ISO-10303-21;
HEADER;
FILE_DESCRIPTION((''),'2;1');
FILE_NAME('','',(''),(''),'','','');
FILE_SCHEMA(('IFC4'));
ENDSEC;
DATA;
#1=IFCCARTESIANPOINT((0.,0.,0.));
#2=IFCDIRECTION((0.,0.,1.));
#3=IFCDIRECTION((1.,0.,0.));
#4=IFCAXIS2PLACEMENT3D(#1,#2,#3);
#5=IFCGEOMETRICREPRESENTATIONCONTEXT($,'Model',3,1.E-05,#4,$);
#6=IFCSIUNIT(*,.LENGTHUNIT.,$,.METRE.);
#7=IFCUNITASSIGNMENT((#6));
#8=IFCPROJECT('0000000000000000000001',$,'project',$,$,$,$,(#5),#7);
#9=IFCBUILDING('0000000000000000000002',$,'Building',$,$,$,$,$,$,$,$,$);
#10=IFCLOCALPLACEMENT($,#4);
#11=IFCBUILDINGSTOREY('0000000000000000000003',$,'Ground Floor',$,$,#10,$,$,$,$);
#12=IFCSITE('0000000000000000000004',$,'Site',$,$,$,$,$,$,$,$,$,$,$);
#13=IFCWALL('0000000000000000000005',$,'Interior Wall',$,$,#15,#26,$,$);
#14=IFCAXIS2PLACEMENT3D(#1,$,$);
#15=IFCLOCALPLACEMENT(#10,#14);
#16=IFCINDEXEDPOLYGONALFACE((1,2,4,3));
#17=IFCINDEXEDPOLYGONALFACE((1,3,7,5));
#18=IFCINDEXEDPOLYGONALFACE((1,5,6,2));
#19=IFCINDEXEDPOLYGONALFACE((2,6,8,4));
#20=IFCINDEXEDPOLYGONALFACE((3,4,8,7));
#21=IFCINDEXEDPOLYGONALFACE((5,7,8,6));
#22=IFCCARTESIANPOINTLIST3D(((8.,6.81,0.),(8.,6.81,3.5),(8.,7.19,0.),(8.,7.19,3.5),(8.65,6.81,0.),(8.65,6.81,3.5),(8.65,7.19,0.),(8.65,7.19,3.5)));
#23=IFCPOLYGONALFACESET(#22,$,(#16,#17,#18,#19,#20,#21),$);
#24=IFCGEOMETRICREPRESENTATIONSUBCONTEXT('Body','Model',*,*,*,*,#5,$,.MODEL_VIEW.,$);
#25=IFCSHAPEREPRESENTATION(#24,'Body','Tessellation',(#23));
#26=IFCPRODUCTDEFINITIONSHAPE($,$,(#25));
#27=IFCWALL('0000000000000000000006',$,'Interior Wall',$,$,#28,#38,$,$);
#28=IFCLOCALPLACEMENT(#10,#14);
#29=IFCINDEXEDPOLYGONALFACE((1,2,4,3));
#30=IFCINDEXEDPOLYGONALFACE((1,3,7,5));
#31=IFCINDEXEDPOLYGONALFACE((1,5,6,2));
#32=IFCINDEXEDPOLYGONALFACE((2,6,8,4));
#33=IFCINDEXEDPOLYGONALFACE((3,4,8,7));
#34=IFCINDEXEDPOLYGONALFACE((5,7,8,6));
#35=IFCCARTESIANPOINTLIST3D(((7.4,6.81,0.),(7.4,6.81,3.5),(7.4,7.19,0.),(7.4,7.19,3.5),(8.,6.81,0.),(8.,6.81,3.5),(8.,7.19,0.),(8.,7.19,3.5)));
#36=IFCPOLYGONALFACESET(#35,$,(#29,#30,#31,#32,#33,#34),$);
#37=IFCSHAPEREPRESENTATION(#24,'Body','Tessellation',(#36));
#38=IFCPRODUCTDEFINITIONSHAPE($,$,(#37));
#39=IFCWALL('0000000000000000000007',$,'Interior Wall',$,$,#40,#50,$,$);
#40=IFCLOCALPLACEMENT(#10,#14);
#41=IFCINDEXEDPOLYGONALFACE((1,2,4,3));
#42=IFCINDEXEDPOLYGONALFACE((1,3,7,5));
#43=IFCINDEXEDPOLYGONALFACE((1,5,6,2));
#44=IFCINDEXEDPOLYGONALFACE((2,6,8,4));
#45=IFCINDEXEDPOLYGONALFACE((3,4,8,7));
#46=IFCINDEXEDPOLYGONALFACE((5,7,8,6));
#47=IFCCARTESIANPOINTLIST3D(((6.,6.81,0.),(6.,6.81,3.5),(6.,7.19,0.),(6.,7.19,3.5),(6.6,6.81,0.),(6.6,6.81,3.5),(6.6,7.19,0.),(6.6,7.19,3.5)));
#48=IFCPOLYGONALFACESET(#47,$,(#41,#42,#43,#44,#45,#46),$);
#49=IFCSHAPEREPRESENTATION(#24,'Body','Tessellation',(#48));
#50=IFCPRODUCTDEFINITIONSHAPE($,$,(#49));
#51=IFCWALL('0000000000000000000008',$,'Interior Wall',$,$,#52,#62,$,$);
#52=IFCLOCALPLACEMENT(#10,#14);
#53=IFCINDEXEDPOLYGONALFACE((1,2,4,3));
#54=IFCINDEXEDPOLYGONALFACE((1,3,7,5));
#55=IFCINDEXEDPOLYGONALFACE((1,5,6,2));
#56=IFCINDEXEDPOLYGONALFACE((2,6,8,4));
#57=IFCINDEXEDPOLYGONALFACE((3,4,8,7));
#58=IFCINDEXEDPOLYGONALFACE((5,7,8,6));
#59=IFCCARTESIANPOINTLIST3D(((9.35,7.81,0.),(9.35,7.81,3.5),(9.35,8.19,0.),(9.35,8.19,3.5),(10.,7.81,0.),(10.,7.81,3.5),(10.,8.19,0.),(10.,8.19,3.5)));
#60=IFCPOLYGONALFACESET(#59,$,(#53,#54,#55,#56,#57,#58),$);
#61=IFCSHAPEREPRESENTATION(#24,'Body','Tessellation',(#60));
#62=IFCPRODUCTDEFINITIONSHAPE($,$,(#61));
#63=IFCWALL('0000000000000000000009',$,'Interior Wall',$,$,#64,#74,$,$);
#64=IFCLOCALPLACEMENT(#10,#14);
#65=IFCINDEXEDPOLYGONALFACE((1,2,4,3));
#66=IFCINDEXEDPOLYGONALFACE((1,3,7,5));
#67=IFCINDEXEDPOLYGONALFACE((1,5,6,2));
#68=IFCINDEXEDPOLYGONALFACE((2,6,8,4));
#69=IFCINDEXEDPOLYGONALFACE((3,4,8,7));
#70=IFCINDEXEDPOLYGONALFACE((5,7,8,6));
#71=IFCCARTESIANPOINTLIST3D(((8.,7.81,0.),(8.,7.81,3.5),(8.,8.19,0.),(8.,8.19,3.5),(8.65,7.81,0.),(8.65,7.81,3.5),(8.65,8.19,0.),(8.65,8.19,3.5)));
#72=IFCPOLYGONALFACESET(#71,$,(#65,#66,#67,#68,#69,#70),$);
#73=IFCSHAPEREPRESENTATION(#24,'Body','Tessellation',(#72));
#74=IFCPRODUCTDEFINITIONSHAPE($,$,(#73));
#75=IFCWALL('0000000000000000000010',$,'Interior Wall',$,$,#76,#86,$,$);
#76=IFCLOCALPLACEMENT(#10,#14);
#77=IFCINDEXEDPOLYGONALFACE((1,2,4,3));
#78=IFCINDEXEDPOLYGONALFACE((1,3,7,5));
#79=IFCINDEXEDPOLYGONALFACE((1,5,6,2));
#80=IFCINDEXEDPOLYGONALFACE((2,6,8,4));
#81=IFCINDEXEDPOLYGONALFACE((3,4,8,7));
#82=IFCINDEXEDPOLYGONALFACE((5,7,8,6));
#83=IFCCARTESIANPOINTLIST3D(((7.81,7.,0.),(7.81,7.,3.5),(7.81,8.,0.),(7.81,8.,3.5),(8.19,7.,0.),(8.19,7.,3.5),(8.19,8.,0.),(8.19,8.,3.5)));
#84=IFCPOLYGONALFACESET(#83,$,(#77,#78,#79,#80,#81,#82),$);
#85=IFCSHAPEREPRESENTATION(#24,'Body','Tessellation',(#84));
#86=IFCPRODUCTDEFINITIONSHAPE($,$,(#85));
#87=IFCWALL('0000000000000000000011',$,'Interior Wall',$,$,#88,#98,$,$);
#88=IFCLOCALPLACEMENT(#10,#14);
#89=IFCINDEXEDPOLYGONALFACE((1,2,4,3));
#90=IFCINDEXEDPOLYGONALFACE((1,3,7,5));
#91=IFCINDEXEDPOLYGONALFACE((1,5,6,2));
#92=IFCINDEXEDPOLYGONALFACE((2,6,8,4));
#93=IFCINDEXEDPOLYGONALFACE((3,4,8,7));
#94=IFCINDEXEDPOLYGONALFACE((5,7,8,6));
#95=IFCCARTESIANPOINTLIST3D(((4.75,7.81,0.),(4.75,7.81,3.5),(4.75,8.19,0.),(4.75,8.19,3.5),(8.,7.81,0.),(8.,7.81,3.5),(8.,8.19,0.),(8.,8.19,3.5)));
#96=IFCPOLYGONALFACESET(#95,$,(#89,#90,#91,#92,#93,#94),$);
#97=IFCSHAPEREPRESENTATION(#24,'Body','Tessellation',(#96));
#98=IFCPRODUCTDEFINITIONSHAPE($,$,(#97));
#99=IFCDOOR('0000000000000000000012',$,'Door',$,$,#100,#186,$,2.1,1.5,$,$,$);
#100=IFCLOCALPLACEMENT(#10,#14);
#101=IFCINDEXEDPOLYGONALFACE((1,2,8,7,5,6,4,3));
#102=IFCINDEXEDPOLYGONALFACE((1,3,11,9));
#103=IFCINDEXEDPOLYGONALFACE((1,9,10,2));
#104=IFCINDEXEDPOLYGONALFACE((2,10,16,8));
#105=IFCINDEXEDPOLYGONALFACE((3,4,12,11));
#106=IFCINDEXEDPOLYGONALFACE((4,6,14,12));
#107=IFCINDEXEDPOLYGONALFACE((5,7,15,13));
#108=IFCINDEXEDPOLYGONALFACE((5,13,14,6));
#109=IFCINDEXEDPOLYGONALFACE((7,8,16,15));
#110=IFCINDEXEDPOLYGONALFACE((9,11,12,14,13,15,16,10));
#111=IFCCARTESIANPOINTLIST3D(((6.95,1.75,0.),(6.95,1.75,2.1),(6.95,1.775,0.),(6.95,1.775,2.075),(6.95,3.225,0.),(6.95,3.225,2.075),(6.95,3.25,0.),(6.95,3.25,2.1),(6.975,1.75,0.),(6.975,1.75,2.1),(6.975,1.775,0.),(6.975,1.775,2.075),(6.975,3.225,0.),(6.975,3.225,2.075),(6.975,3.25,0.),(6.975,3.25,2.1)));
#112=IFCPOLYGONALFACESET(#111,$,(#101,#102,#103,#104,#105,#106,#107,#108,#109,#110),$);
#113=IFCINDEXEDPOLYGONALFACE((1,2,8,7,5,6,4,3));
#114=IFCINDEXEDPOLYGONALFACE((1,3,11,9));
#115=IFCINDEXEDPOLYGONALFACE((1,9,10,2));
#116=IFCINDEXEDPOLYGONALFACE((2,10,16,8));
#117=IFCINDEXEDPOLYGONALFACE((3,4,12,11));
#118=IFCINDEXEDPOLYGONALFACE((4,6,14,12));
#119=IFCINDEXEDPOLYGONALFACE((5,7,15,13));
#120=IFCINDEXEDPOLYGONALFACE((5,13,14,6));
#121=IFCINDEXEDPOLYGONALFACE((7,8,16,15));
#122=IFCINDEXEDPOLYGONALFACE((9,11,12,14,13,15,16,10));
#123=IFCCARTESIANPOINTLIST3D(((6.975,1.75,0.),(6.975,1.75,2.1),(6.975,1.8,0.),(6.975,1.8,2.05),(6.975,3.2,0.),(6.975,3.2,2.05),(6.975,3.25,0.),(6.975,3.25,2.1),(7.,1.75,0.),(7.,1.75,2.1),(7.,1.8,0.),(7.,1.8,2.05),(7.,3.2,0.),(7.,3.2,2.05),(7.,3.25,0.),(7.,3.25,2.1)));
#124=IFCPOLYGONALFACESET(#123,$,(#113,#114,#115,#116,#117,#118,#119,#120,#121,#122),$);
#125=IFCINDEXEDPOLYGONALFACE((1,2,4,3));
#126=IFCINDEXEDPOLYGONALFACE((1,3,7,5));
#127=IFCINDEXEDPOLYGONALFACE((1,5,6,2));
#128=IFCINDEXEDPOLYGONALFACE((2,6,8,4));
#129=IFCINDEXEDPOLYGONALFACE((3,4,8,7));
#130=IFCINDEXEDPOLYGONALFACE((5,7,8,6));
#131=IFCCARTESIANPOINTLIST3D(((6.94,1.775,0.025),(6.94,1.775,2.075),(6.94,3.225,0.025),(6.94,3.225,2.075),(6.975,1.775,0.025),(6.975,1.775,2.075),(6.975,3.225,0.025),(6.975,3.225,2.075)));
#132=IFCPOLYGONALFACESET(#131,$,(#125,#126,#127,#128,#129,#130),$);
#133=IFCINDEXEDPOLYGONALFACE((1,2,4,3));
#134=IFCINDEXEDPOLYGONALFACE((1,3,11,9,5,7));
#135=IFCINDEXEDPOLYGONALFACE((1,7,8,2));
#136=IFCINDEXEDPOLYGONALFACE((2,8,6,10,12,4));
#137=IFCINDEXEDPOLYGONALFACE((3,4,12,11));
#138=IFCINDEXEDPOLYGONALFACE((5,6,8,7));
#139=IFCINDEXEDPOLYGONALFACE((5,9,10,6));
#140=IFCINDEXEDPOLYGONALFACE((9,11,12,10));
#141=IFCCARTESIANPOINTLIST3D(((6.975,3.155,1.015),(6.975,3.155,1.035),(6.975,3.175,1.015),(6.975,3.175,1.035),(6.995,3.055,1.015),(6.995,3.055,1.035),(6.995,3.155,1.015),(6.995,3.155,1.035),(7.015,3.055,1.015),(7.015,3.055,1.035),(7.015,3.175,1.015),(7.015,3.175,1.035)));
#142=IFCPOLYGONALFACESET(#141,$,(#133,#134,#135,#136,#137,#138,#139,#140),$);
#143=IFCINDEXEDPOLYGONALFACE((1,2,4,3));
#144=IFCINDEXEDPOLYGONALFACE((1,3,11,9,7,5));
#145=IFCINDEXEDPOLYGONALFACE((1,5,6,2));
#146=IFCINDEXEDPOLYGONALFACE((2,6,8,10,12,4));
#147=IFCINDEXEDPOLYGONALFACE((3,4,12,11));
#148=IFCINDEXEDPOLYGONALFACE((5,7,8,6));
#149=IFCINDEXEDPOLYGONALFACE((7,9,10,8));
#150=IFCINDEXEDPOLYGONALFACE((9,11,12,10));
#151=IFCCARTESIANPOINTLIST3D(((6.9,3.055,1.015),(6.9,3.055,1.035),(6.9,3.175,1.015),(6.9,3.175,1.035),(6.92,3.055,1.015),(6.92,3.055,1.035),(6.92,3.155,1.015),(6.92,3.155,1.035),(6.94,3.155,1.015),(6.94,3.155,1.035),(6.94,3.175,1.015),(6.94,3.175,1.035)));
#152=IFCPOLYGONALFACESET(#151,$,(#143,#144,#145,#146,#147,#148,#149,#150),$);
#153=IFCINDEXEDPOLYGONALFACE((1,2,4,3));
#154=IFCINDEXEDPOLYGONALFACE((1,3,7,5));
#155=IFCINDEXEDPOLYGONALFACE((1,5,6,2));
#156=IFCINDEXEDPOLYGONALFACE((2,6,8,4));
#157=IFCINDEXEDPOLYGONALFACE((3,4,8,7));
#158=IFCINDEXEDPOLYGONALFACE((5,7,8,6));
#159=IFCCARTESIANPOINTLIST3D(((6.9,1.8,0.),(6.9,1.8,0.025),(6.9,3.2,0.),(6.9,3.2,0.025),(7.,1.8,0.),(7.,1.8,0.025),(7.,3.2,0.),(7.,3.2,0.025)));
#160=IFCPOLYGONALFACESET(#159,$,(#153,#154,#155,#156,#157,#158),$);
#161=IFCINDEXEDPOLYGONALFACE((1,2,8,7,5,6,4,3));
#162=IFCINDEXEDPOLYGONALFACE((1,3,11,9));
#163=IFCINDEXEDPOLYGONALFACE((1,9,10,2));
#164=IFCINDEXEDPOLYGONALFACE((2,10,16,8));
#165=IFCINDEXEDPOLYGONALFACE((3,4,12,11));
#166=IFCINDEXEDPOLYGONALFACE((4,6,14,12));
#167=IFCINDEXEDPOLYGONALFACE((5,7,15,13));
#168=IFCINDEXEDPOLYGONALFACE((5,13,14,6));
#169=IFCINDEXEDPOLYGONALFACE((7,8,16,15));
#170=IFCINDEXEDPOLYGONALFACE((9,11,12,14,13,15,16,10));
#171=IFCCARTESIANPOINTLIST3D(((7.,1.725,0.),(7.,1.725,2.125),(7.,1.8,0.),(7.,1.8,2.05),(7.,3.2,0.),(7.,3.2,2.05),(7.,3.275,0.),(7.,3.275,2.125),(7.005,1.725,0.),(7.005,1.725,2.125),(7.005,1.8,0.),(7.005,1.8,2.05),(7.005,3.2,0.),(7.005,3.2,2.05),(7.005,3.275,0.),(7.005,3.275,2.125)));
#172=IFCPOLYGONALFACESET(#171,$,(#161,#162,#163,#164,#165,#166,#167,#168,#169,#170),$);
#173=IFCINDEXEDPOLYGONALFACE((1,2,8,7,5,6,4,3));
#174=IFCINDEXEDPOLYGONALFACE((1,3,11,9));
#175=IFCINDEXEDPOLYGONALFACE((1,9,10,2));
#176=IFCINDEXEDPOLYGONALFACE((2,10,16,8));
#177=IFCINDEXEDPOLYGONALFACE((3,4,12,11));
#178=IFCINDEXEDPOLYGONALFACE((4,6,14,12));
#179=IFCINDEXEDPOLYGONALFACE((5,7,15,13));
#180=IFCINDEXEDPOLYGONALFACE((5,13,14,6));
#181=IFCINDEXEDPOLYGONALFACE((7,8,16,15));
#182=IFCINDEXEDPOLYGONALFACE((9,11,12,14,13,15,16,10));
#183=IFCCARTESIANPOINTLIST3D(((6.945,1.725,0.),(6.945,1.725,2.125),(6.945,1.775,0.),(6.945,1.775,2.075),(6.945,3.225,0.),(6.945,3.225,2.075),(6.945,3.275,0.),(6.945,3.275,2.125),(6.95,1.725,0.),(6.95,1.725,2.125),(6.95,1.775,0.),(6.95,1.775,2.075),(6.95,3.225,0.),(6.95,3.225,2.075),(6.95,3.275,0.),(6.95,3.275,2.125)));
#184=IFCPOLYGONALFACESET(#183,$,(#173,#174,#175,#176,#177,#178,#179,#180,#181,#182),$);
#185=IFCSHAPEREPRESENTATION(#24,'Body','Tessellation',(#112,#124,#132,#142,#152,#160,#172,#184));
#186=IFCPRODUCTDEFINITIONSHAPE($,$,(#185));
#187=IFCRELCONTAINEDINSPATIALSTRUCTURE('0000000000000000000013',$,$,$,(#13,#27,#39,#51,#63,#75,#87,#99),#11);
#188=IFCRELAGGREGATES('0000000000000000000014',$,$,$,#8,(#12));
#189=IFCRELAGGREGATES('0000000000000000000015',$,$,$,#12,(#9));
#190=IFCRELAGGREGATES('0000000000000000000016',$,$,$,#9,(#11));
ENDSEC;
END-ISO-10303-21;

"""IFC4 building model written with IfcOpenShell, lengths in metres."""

from ifc_helpers import new_model, si_unit, frame, origin_with_axes, place, context, subcontext, project, spatial, line, indexed_curve, outline, extrude, element, save


model = new_model("IFC4")

# Units and contexts
model_context = context("Model", 3, precision=1e-05, world=origin_with_axes())
body_context = subcontext(model_context, "Body", "Model", "MODEL_VIEW")
ifc_project = project(units=[si_unit("LENGTHUNIT", "METRE")], contexts=[model_context])

# Site, building, storey
site = spatial("IfcSite", under=ifc_project, Name="Site")
building = spatial("IfcBuilding", under=site, Name="Building")
storey_placement = place(None, origin_with_axes())
storey = spatial("IfcBuildingStorey", under=building, at=storey_placement, Name="Ground Floor")

# Walls
for number, where, z_axis, x_axis, name in (
    (1, (8.65, 7.0, 0.0), (0.0, 0.0, 1.0), (-1.0, 0.0, 0.0), "Interior Wall"),
):
    element("IfcWall", number, at=place(storey_placement, frame(where, z_axis=z_axis, x_axis=x_axis)), inside=storey, Name=name, context=body_context, shape_type="SweptSolid", body=[
        extrude(outline(indexed_curve([(0.0, 0.0), (0.0, 0.38), (0.65, 0.38), (0.65, 0.0), (0.0, 0.0)], self_intersect=False)), frame((0.0, -0.19, 0.0), z_axis=(0.0, 0.0, 1.0), x_axis=(1.0, 0.0, 0.0)), (0.0, 0.0, 1.0), 3.5),
    ])
for number, where, z_axis, x_axis, name in (
    (2, (8.0, 7.0, 0.0), (0.0, 0.0, 1.0), (-1.0, 0.0, 0.0), "Interior Wall"),
    (3, (6.6, 7.0, 0.0), (0.0, 0.0, 1.0), (-1.0, 0.0, 0.0), "Interior Wall"),
):
    element("IfcWall", number, at=place(storey_placement, frame(where, z_axis=z_axis, x_axis=x_axis)), inside=storey, Name=name, context=body_context, shape_type="SweptSolid", body=[
        extrude(outline(indexed_curve([(0.0, 0.0), (0.0, 0.38), (0.6, 0.38), (0.6, 0.0), (0.0, 0.0)], self_intersect=False)), frame((0.0, -0.19, 0.0), z_axis=(0.0, 0.0, 1.0), x_axis=(1.0, 0.0, 0.0)), (0.0, 0.0, 1.0), 3.5),
    ])
for number, where, z_axis, x_axis, name in (
    (4, (10.0, 8.0, 0.0), (0.0, 0.0, 1.0), (-1.0, 0.0, 0.0), "Interior Wall"),
    (5, (8.65, 8.0, 0.0), (0.0, 0.0, 1.0), (-1.0, 0.0, 0.0), "Interior Wall"),
):
    element("IfcWall", number, at=place(storey_placement, frame(where, z_axis=z_axis, x_axis=x_axis)), inside=storey, Name=name, context=body_context, shape_type="SweptSolid", body=[
        extrude(outline(indexed_curve([(0.0, 0.0), (0.0, 0.38), (0.65, 0.38), (0.65, 0.0), (0.0, 0.0)], self_intersect=False)), frame((0.0, -0.19, 0.0), z_axis=(0.0, 0.0, 1.0), x_axis=(1.0, 0.0, 0.0)), (0.0, 0.0, 1.0), 3.5),
    ])
wall_1_placement = place(storey_placement, frame((8.0, 8.0, 0.0), z_axis=(0.0, 0.0, 1.0), x_axis=(0.0, -1.0, 0.0)))
element("IfcWall", 6, at=wall_1_placement, inside=storey, Name="Interior Wall", context=body_context, shape_type="SweptSolid", body=[
    extrude(outline(indexed_curve([(0.0, 0.0), (0.0, 0.38), (1.0, 0.38), (1.0, 0.0), (0.0, 0.0)], self_intersect=False)), frame((0.0, -0.19, 0.0), z_axis=(0.0, 0.0, 1.0), x_axis=(1.0, 0.0, 0.0)), (0.0, 0.0, 1.0), 3.5),
])
wall_2_placement = place(storey_placement, frame((4.75, 8.0, 0.0), z_axis=(0.0, 0.0, 1.0), x_axis=(1.0, 0.0, 0.0)))
element("IfcWall", 7, at=wall_2_placement, inside=storey, Name="Interior Wall", context=body_context, shape_type="SweptSolid", body=[
    extrude(outline(indexed_curve([(0.0, 0.0), (0.0, 0.38), (3.25, 0.38), (3.25, 0.0), (0.0, 0.0)], self_intersect=False)), frame((0.0, -0.19, 0.0), z_axis=(0.0, 0.0, 1.0), x_axis=(1.0, 0.0, 0.0)), (0.0, 0.0, 1.0), 3.5),
])

# Door
door_1_placement = place(storey_placement, frame((7.0, 1.75, 0.0), z_axis=(0.0, 0.0, 1.0), x_axis=(0.0, 1.0, 0.0)))
element("IfcDoor", 8, at=door_1_placement, inside=storey, Name="Door", OverallHeight=2.1, OverallWidth=1.5, context=body_context, shape_type="SweptSolid", body=[
    extrude(outline(indexed_curve([(0.0, 0.0), (0.0, 2.1), (1.5, 2.1), (1.5, 0.0), (1.475, 0.0), (1.475, 2.075), (0.025, 2.075), (0.025, 0.0)], segments=[line(1, 2, 3, 4, 5, 6, 7, 8, 1)])), frame((0.0, 0.025, 0.0), z_axis=(0.0, -1.0, 0.0), x_axis=(1.0, 0.0, 0.0)), (0.0, 0.0, -1.0), 0.025),
    extrude(outline(indexed_curve([(0.0, 0.0), (0.0, 2.1), (1.5, 2.1), (1.5, 0.0), (1.45, 0.0), (1.45, 2.05), (0.05, 2.05), (0.05, 0.0)], segments=[line(1, 2, 3, 4, 5, 6, 7, 8, 1)])), frame((0.0, 0.0, 0.0), z_axis=(0.0, -1.0, 0.0), x_axis=(1.0, 0.0, 0.0)), (0.0, 0.0, -1.0), 0.025),
    extrude(outline(indexed_curve([(0.0, 0.0), (1.45, 0.0), (1.45, 0.035), (0.0, 0.035)], segments=[line(1, 2, 3, 4, 1)])), frame((0.025, 0.025, 0.025), z_axis=(0.0, 0.0, 1.0), x_axis=(1.0, 0.0, 0.0)), (0.0, 0.0, 1.0), 2.05),
    extrude(outline(indexed_curve([(0.0, 0.0), (0.0, -0.04), (-0.12, -0.04), (-0.12, -0.02), (-0.02, -0.02), (-0.02, 0.0)], segments=[line(1, 2, 3, 4, 5, 6, 1)])), frame((1.425, 0.025, 1.015), z_axis=(0.0, 0.0, 1.0), x_axis=(1.0, 0.0, 0.0)), (0.0, 0.0, 1.0), 0.02),
    extrude(outline(indexed_curve([(0.0, 0.0), (0.0, 0.04), (-0.12, 0.04), (-0.12, 0.02), (-0.02, 0.02), (-0.02, 0.0)], segments=[line(1, 2, 3, 4, 5, 6, 1)])), frame((1.425, 0.06, 1.015), z_axis=(0.0, 0.0, 1.0), x_axis=(1.0, 0.0, 0.0)), (0.0, 0.0, 1.0), 0.02),
    extrude(outline(indexed_curve([(0.0, 0.0), (1.4, 0.0), (1.4, 0.1), (0.0, 0.1)], segments=[line(1, 2, 3, 4, 1)])), frame((0.05, 0.0, 0.0), z_axis=(0.0, 0.0, 1.0), x_axis=(1.0, 0.0, 0.0)), (0.0, 0.0, 1.0), 0.025),
    extrude(outline(indexed_curve([(0.0, 0.0), (0.0, 2.125), (1.55, 2.125), (1.55, 0.0), (1.475, 0.0), (1.475, 2.05), (0.075, 2.05), (0.075, 0.0)], segments=[line(1, 2, 3, 4, 5, 6, 7, 8, 1)])), frame((-0.025, -0.005, 0.0), z_axis=(0.0, -1.0, 0.0), x_axis=(1.0, 0.0, 0.0)), (0.0, 0.0, -1.0), 0.005),
    extrude(outline(indexed_curve([(0.0, 0.0), (0.0, 2.125), (1.55, 2.125), (1.55, 0.0), (1.5, 0.0), (1.5, 2.075), (0.05, 2.075), (0.05, 0.0)], segments=[line(1, 2, 3, 4, 5, 6, 7, 8, 1)])), frame((-0.025, 0.05, 0.0), z_axis=(0.0, -1.0, 0.0), x_axis=(1.0, 0.0, 0.0)), (0.0, 0.0, -1.0), 0.005),
])

save(model, "model.ifc")
